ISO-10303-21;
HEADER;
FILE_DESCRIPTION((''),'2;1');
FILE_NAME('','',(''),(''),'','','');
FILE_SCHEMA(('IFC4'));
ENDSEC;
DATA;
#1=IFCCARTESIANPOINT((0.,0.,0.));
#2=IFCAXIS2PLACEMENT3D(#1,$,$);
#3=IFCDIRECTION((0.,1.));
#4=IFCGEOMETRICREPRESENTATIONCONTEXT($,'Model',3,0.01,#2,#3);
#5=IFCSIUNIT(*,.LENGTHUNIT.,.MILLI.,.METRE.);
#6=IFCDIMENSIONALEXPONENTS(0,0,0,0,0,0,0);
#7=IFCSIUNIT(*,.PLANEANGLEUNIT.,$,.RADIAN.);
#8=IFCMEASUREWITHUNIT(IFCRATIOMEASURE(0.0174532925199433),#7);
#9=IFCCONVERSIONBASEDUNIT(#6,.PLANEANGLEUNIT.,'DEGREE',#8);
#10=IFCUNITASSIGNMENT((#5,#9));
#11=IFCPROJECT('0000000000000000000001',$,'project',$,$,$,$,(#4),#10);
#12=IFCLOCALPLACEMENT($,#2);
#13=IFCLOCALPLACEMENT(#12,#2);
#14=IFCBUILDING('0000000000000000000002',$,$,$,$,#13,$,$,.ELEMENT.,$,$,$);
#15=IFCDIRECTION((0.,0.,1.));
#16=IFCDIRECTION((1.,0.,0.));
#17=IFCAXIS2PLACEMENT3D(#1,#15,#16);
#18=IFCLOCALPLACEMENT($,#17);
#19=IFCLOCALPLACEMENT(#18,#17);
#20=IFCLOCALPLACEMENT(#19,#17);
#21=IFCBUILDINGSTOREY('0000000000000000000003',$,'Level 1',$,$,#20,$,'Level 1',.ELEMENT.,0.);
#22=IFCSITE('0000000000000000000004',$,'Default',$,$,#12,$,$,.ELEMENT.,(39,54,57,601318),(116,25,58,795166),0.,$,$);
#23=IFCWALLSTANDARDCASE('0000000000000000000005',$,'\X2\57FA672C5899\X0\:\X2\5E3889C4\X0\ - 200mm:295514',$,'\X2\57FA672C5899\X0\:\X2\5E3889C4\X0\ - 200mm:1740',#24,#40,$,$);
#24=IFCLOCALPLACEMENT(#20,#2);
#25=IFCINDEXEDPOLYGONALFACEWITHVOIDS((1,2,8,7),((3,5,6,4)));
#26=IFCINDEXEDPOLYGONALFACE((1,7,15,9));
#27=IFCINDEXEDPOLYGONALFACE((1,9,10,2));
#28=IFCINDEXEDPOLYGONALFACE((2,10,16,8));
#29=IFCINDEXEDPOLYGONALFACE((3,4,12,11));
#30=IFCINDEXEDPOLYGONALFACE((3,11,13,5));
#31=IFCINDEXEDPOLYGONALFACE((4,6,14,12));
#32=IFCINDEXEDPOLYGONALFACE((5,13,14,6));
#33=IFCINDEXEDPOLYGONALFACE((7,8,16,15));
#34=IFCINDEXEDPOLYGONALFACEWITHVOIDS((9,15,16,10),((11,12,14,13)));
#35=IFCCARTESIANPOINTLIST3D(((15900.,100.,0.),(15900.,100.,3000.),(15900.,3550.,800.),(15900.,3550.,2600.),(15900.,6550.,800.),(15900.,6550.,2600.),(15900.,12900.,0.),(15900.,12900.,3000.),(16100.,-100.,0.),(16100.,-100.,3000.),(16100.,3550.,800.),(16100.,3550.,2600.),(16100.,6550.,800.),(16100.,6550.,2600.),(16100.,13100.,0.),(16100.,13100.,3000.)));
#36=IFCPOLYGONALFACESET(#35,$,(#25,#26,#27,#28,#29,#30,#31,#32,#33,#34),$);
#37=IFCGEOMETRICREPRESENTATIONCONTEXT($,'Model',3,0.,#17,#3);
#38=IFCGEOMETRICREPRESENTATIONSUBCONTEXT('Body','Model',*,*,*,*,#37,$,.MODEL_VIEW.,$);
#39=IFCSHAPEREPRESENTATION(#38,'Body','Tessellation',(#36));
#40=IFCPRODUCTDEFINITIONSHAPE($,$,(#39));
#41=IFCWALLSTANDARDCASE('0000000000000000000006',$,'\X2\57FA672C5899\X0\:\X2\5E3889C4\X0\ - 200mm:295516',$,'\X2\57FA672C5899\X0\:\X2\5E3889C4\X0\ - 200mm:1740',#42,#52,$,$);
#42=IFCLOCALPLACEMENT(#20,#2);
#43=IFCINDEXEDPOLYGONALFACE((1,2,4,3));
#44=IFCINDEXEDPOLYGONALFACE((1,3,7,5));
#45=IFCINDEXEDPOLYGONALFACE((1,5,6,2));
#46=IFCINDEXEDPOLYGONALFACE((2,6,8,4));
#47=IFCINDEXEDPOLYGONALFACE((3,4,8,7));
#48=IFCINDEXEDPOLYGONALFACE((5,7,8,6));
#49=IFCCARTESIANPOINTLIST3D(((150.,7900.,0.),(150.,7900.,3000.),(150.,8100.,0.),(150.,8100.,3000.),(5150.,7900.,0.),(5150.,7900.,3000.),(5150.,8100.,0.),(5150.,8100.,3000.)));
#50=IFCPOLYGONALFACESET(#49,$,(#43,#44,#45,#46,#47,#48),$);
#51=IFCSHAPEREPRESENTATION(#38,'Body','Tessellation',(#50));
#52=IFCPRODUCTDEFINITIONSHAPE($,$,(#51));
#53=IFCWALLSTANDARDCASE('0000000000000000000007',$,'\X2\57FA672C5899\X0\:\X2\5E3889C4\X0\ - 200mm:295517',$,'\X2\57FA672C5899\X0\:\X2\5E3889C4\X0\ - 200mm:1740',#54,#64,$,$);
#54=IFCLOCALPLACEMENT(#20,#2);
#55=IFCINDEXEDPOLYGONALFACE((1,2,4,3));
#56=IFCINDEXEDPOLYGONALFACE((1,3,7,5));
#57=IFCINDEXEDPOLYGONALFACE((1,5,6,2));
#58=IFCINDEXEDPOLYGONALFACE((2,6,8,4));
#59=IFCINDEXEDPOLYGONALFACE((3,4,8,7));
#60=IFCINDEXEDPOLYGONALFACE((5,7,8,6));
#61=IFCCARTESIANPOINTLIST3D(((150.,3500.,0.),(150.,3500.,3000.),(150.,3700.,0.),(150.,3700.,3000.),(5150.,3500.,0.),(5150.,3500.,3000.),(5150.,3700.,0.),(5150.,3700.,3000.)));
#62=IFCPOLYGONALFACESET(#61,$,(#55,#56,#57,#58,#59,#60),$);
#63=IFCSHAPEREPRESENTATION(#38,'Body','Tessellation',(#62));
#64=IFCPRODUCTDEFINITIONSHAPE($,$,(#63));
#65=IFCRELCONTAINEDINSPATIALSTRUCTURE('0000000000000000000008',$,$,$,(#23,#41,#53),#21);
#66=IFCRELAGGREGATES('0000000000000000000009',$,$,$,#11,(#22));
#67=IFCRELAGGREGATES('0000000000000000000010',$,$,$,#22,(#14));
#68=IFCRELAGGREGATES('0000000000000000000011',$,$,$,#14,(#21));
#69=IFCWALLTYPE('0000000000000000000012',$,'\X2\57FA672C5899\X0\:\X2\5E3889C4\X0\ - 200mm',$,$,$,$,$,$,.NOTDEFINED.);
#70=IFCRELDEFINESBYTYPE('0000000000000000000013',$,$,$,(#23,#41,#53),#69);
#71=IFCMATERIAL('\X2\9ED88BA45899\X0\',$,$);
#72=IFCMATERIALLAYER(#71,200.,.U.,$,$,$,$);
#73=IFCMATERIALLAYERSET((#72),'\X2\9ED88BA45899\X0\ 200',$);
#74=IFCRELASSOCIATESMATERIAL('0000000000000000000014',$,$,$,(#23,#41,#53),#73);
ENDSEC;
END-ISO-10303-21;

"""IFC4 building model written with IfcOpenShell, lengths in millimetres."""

from ifc_helpers import new_model, entity, si_unit, converted_unit, direction, frame, origin, origin_with_axes, place, context, subcontext, project, spatial, polyline, outline, extrude, material, layer, layer_set, layer_usage, type_object, element, save


model = new_model("IFC4")

# Units and contexts
model_context_1 = context("Model", 3, precision=0.01, world=origin(), true_north=direction((0.0, 1.0)))
model_context_2 = context("Model", 3, precision=0.0, world=origin_with_axes(), true_north=direction((0.0, 1.0)))
body_context = subcontext(model_context_2, "Body", "Model", "MODEL_VIEW")
ifc_project = project(units=[si_unit("LENGTHUNIT", "METRE", prefix="MILLI"), converted_unit("PLANEANGLEUNIT", "DEGREE", entity("IfcRatioMeasure", 0.0174532925199433), si_unit("PLANEANGLEUNIT", "RADIAN"), dimensions=[0, 0, 0, 0, 0, 0, 0])], contexts=[model_context_1])

# Site, building, storey
site_placement = place(None, origin())
site = spatial("IfcSite", under=ifc_project, at=site_placement, Name="Default", CompositionType="ELEMENT", RefLatitude=(39, 54, 57, 601318), RefLongitude=(116, 25, 58, 795166), RefElevation=0.0)
building_placement = place(site_placement, origin())
building = spatial("IfcBuilding", under=site, at=building_placement, CompositionType="ELEMENT")
placement_1 = place(None, origin_with_axes())
placement_2 = place(placement_1, origin_with_axes())
storey_placement = place(placement_2, origin_with_axes())
storey = spatial("IfcBuildingStorey", under=building, at=storey_placement, Name="Level 1", LongName="Level 1", CompositionType="ELEMENT", Elevation=0.0)

# Shared definitions
ifc_material_1 = material(Name="默认墙")
ifc_layer_1 = layer(ifc_material_1, 200.0, ventilated="UNKNOWN")
ifc_layer_set_1 = layer_set([ifc_layer_1], Name="默认墙 200")
wall_type = type_object("IfcWallType", Name="基本墙:常规 - 200mm", PredefinedType="NOTDEFINED")

# Wall, opening
ifc_layer_usage_1 = layer_usage(ifc_layer_set_1, "AXIS2", "POSITIVE", -100.0)
wall_1_placement = place(storey_placement, frame((16000.0, 13000.0, 0.0), z_axis=(0.0, 0.0, 1.0), x_axis=(0.0, -1.0, 0.0)))
wall_1 = element("IfcWallStandardCase", 1, at=wall_1_placement, inside=storey, type_object=wall_type, material=ifc_layer_usage_1, Name="基本墙:常规 - 200mm:295514", ObjectType="基本墙:常规 - 200mm:1740", context=body_context, shape_type="SweptSolid", body=[
    extrude(outline(polyline([(100.0, -100.0), (12900.0, -100.0), (13100.0, 100.0), (-100.0, 100.0), (100.0, -100.0)])), origin_with_axes(), (0.0, 0.0, 1.0), 3000.0),
])
opening_1_placement = place(wall_1_placement, frame((7950.0, 0.0, 800.0), z_axis=(0.0, 0.0, 1.0), x_axis=(1.0, 0.0, 0.0)))
element("IfcOpeningElement", 2, at=opening_1_placement, cuts=wall_1, context=body_context, shape_type="SweptSolid", body=[
    extrude(outline(polyline([(-1500.0, 0.0), (-1500.0, -1800.0), (1500.0, -1800.0), (1500.0, 0.0), (-1500.0, 0.0)])), frame((0.0, -100.0, 0.0), z_axis=(0.0, 1.0, 0.0), x_axis=(1.0, 0.0, 0.0)), (0.0, 0.0, 1.0), 200.0),
])

# Walls
ifc_layer_usage_2 = layer_usage(ifc_layer_set_1, "AXIS2", "POSITIVE", -100.0)
wall_2_placement = place(storey_placement, frame((150.0, 8000.0, 0.0), z_axis=(0.0, 0.0, 1.0), x_axis=(1.0, 0.0, 0.0)))
element("IfcWallStandardCase", 3, at=wall_2_placement, inside=storey, type_object=wall_type, material=ifc_layer_usage_2, Name="基本墙:常规 - 200mm:295516", ObjectType="基本墙:常规 - 200mm:1740", context=body_context, shape_type="SweptSolid", body=[
    extrude(outline(polyline([(0.0, -100.0), (5000.0, -100.0), (5000.0, 100.0), (0.0, 100.0), (0.0, -100.0)])), origin_with_axes(), (0.0, 0.0, 1.0), 3000.0),
])
ifc_layer_usage_3 = layer_usage(ifc_layer_set_1, "AXIS2", "POSITIVE", -100.0)
wall_3_placement = place(storey_placement, frame((150.0, 3600.0, 0.0), z_axis=(0.0, 0.0, 1.0), x_axis=(1.0, 0.0, 0.0)))
element("IfcWallStandardCase", 4, at=wall_3_placement, inside=storey, type_object=wall_type, material=ifc_layer_usage_3, Name="基本墙:常规 - 200mm:295517", ObjectType="基本墙:常规 - 200mm:1740", context=body_context, shape_type="SweptSolid", body=[
    extrude(outline(polyline([(0.0, -100.0), (5000.0, -100.0), (5000.0, 100.0), (0.0, 100.0), (0.0, -100.0)])), origin_with_axes(), (0.0, 0.0, 1.0), 3000.0),
])

save(model, "model.ifc")
